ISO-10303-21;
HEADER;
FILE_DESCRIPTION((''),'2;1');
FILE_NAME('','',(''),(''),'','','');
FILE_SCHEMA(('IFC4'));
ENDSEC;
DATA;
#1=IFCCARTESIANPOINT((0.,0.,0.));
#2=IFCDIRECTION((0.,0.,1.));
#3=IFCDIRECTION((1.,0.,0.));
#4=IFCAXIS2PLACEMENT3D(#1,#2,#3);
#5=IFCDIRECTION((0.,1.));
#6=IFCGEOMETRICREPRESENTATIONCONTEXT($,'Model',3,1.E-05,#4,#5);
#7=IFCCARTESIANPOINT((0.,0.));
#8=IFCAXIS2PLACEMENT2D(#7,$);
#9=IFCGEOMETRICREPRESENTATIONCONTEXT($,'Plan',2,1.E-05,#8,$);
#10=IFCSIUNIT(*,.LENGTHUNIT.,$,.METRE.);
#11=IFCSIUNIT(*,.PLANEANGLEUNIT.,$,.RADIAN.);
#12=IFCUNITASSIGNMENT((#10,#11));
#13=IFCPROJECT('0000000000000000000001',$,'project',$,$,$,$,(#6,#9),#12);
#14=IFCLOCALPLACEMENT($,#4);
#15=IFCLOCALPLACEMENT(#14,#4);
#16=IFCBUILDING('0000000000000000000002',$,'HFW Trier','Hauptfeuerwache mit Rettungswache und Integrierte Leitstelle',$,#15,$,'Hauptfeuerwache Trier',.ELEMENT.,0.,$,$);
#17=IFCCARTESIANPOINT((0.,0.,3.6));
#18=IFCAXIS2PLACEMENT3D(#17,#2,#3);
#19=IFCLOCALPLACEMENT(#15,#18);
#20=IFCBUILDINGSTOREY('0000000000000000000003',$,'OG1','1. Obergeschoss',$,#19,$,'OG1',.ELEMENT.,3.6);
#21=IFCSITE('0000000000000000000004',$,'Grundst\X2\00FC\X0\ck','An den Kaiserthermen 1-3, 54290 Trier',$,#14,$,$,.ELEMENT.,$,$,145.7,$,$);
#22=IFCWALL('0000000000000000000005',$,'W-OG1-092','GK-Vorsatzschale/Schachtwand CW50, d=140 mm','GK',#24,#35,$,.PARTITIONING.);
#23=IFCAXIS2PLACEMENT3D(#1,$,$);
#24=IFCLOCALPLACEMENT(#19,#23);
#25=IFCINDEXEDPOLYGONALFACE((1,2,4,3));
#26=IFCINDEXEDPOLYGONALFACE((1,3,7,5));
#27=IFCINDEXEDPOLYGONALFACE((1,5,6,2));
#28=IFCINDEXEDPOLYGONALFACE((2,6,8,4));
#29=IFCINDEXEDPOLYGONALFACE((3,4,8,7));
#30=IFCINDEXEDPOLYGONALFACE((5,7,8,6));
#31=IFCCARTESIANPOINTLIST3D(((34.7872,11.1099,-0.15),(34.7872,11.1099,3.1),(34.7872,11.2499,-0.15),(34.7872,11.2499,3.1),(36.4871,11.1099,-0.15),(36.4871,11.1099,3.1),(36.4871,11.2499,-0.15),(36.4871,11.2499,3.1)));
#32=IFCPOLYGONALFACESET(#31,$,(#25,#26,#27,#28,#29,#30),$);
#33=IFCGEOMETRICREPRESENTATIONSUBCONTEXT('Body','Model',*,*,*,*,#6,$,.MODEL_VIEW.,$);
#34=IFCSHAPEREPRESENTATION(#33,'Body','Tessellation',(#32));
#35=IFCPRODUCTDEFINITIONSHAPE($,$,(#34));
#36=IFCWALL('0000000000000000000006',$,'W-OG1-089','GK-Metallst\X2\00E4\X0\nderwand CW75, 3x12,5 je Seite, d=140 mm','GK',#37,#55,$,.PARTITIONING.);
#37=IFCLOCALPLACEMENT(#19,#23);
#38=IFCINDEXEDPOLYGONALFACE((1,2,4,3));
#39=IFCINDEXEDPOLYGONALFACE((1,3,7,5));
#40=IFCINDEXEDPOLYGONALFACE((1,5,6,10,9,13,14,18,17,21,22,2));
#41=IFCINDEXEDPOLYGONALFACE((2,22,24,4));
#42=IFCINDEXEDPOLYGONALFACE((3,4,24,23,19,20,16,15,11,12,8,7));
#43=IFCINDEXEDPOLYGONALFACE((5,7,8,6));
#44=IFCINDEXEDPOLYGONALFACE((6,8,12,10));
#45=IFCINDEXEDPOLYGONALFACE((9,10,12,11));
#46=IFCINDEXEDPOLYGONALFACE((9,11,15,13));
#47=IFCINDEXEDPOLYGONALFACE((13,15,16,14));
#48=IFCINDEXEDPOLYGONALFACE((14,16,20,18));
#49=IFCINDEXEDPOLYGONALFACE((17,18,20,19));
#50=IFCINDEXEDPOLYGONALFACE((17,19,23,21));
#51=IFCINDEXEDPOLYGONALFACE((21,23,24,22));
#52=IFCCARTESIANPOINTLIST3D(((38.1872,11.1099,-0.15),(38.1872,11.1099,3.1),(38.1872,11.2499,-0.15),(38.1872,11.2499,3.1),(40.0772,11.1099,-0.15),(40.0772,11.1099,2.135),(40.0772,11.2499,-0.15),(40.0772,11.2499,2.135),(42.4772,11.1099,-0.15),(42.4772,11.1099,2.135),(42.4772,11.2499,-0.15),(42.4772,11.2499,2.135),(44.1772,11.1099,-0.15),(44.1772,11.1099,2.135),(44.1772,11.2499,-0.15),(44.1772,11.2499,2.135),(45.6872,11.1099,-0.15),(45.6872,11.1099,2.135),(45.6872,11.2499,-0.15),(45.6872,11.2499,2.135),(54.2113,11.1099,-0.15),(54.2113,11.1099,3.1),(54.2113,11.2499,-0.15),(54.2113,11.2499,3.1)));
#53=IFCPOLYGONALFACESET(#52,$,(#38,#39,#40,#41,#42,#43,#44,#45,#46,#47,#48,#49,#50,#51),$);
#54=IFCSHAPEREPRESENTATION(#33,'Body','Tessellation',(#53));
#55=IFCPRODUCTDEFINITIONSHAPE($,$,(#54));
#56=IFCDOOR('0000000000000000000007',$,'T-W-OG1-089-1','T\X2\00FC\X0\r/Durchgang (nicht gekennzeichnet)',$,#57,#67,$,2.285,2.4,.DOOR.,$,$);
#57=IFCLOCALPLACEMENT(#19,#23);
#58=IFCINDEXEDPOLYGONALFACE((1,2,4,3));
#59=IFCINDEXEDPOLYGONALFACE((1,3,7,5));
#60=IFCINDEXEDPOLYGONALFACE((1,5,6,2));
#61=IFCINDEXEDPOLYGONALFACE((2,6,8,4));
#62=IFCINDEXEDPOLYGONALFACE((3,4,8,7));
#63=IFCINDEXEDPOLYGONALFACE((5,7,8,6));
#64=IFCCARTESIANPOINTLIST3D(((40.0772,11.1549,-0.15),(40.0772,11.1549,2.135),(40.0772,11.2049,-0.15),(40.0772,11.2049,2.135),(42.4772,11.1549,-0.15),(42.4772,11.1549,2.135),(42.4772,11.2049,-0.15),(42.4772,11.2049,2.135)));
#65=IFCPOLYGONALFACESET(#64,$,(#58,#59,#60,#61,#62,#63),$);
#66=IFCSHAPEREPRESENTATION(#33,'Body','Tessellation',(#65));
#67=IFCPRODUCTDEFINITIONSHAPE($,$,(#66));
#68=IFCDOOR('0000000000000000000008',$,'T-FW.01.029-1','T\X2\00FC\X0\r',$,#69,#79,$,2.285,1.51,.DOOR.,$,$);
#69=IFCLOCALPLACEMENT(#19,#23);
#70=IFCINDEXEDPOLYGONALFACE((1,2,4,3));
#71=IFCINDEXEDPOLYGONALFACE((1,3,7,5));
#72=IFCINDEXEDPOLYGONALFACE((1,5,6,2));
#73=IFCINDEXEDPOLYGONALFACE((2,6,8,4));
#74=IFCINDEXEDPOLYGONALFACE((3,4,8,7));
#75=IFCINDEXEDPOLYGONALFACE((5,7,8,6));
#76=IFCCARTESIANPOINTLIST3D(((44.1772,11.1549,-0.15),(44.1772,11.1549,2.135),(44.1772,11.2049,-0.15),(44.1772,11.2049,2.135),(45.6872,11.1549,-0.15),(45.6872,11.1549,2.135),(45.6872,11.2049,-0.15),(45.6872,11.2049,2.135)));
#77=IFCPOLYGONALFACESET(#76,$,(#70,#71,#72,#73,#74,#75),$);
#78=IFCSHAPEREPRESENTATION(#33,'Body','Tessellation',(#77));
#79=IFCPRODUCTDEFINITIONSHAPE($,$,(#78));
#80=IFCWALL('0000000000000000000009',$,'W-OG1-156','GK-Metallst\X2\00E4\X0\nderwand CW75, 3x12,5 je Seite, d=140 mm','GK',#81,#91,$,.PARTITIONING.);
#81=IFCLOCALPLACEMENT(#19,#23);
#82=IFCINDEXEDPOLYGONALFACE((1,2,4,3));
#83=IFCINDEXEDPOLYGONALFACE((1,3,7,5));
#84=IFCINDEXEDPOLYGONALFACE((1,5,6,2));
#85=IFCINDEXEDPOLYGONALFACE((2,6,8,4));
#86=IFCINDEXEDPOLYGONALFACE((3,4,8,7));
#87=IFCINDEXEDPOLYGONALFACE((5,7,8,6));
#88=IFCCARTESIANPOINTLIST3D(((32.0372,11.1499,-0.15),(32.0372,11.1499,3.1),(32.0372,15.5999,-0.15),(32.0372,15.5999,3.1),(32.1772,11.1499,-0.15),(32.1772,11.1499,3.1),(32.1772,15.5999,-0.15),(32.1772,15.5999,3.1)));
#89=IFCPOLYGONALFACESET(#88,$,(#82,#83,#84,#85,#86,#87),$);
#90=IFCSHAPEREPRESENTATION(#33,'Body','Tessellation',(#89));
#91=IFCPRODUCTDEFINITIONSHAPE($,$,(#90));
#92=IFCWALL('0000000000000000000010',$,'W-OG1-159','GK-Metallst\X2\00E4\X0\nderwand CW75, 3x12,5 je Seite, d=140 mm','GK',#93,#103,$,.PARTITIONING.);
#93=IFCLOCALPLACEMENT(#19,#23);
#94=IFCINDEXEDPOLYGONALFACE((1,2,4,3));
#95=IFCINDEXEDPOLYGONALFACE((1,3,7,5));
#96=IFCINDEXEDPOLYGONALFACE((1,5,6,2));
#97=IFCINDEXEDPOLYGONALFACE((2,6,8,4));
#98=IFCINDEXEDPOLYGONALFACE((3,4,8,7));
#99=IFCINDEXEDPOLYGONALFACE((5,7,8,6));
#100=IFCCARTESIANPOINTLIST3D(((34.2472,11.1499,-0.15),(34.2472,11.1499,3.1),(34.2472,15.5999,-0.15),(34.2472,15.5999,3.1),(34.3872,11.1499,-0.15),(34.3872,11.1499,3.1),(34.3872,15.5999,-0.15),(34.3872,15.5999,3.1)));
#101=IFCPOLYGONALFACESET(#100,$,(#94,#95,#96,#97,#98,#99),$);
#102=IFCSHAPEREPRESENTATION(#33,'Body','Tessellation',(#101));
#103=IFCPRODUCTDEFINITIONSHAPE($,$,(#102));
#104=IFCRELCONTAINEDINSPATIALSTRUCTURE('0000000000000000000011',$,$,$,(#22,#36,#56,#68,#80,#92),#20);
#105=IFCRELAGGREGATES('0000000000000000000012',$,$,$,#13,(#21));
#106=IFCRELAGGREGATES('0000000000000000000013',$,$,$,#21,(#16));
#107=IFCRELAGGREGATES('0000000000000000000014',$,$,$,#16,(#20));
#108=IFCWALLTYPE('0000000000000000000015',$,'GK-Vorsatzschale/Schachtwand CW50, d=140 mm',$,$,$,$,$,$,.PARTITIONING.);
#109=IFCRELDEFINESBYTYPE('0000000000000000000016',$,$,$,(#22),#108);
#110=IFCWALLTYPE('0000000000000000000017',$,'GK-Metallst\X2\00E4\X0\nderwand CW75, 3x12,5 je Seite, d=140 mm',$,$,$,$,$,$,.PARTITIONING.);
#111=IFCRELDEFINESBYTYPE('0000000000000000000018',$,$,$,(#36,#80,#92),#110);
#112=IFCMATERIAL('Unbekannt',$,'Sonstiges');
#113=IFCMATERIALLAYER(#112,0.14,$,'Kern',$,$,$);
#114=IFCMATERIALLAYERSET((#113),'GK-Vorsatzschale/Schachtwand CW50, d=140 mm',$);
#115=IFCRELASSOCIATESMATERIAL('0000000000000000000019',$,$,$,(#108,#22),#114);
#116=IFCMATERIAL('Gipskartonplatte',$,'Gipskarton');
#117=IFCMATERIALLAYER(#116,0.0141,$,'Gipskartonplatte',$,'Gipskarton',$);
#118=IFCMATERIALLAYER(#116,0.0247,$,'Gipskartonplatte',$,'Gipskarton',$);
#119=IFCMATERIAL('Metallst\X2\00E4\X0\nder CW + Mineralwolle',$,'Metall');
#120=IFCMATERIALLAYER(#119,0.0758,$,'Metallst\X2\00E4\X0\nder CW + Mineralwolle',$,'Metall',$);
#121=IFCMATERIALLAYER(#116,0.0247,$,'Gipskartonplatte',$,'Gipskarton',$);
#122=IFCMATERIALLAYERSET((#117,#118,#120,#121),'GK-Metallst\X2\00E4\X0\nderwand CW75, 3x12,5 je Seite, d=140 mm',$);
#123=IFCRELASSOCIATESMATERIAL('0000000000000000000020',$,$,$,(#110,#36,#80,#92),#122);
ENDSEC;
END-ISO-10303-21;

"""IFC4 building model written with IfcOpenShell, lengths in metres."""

from ifc_helpers import new_model, si_unit, direction, frame, frame_2d, origin_with_axes, origin_2d, place, context, subcontext, project, spatial, rectangle, extrude, material, layer, layer_set, layer_usage, type_object, element, fill, save


model = new_model("IFC4")

# Units and contexts
model_context = context("Model", 3, precision=1e-05, world=origin_with_axes(), true_north=direction((0.0, 1.0)))
plan_context = context("Plan", 2, precision=1e-05, world=origin_2d())
body_context = subcontext(model_context, "Body", "Model", "MODEL_VIEW")
ifc_project = project(units=[si_unit("LENGTHUNIT", "METRE"), si_unit("PLANEANGLEUNIT", "RADIAN")], contexts=[model_context, plan_context])

# Site, building, storey
site_placement = place(None, origin_with_axes())
site = spatial("IfcSite", under=ifc_project, at=site_placement, Name="Grundstück", Description="An den Kaiserthermen 1-3, 54290 Trier", CompositionType="ELEMENT", RefElevation=145.7)
building_placement = place(site_placement, origin_with_axes())
building = spatial("IfcBuilding", under=site, at=building_placement, Name="HFW Trier", Description="Hauptfeuerwache mit Rettungswache und Integrierte Leitstelle", LongName="Hauptfeuerwache Trier", CompositionType="ELEMENT", ElevationOfRefHeight=0.0)
storey_placement = place(building_placement, frame((0.0, 0.0, 3.6), z_axis=(0.0, 0.0, 1.0), x_axis=(1.0, 0.0, 0.0)))
storey = spatial("IfcBuildingStorey", under=building, at=storey_placement, Name="OG1", Description="1. Obergeschoss", LongName="OG1", CompositionType="ELEMENT", Elevation=3.6)

# Wall
ifc_material_1 = material(Name="Gipskartonplatte", Category="Gipskarton")
ifc_material_2 = material(Name="Metallständer CW + Mineralwolle", Category="Metall")
ifc_material_3 = material(Name="Unbekannt", Category="Sonstiges")
ifc_layer_1 = layer(ifc_material_3, 0.14, Name="Kern")
ifc_layer_set_1 = layer_set([ifc_layer_1], Name="GK-Vorsatzschale/Schachtwand CW50, d=140 mm")
wall_type_1 = type_object("IfcWallType", Name="GK-Vorsatzschale/Schachtwand CW50, d=140 mm", PredefinedType="PARTITIONING", material=ifc_layer_set_1)
ifc_layer_usage_1 = layer_usage(ifc_layer_set_1, "AXIS2", "POSITIVE", -0.07)
wall_1_placement = place(storey_placement, frame((34.7872, 11.1799, -0.15), z_axis=(0.0, 0.0, 1.0), x_axis=(1.0, 0.0, 0.0)))
element("IfcWall", 1, at=wall_1_placement, inside=storey, type_object=wall_type_1, material=ifc_layer_usage_1, Name="W-OG1-092", Description="GK-Vorsatzschale/Schachtwand CW50, d=140 mm", ObjectType="GK", PredefinedType="PARTITIONING", context=body_context, shape_type="SweptSolid", body=[
    extrude(rectangle(XDim=1.6999, YDim=0.14, at=frame_2d((0.8499, 0.0))), origin_with_axes(), (0.0, 0.0, 1.0), 3.25),
])

# Wall, openings, doors
ifc_layer_2 = layer(ifc_material_1, 0.0141, Name="Gipskartonplatte", Category="Gipskarton")
ifc_layer_3 = layer(ifc_material_1, 0.0247, Name="Gipskartonplatte", Category="Gipskarton")
ifc_layer_4 = layer(ifc_material_2, 0.0758, Name="Metallständer CW + Mineralwolle", Category="Metall")
ifc_layer_5 = layer(ifc_material_1, 0.0247, Name="Gipskartonplatte", Category="Gipskarton")
ifc_layer_set_2 = layer_set([ifc_layer_2, ifc_layer_3, ifc_layer_4, ifc_layer_5], Name="GK-Metallständerwand CW75, 3x12,5 je Seite, d=140 mm")
ifc_layer_usage_2 = layer_usage(ifc_layer_set_2, "AXIS2", "POSITIVE", -0.07)
wall_type_2 = type_object("IfcWallType", Name="GK-Metallständerwand CW75, 3x12,5 je Seite, d=140 mm", PredefinedType="PARTITIONING", material=ifc_layer_set_2)
wall_2_placement = place(storey_placement, frame((38.1872, 11.1799, -0.15), z_axis=(0.0, 0.0, 1.0), x_axis=(1.0, 0.0, 0.0)))
wall_2 = element("IfcWall", 2, at=wall_2_placement, inside=storey, type_object=wall_type_2, material=ifc_layer_usage_2, Name="W-OG1-089", Description="GK-Metallständerwand CW75, 3x12,5 je Seite, d=140 mm", ObjectType="GK", PredefinedType="PARTITIONING", context=body_context, shape_type="SweptSolid", body=[
    extrude(rectangle(XDim=16.0241, YDim=0.14, at=frame_2d((8.0121, 0.0))), origin_with_axes(), (0.0, 0.0, 1.0), 3.25),
])
opening_1_placement = place(wall_2_placement, frame((1.89, 0.0, 0.0), z_axis=(0.0, 0.0, 1.0), x_axis=(1.0, 0.0, 0.0)))
opening_1 = element("IfcOpeningElement", 3, at=opening_1_placement, cuts=wall_2, PredefinedType="OPENING", context=body_context, shape_type="SweptSolid", body=[
    extrude(rectangle(XDim=2.4, YDim=0.24, at=frame_2d((1.2, 0.0))), origin_with_axes(), (0.0, 0.0, 1.0), 2.285),
])
opening_2_placement = place(wall_2_placement, frame((5.99, 0.0, 0.0), z_axis=(0.0, 0.0, 1.0), x_axis=(1.0, 0.0, 0.0)))
opening_2 = element("IfcOpeningElement", 4, at=opening_2_placement, cuts=wall_2, PredefinedType="OPENING", context=body_context, shape_type="SweptSolid", body=[
    extrude(rectangle(XDim=1.51, YDim=0.24, at=frame_2d((0.755, 0.0))), origin_with_axes(), (0.0, 0.0, 1.0), 2.285),
])
door_1_placement = place(wall_2_placement, frame((1.89, 0.0, 0.0), z_axis=(0.0, 0.0, 1.0), x_axis=(1.0, 0.0, 0.0)))
door_1 = element("IfcDoor", 5, at=door_1_placement, inside=storey, Name="T-W-OG1-089-1", Description="Tür/Durchgang (nicht gekennzeichnet)", OverallHeight=2.285, OverallWidth=2.4, PredefinedType="DOOR", context=body_context, shape_type="SweptSolid", body=[
    extrude(rectangle(XDim=2.4, YDim=0.05, at=frame_2d((1.2, 0.0))), origin_with_axes(), (0.0, 0.0, 1.0), 2.285),
])
fill(opening_1, door_1)
door_2_placement = place(wall_2_placement, frame((5.99, 0.0, 0.0), z_axis=(0.0, 0.0, 1.0), x_axis=(1.0, 0.0, 0.0)))
door_2 = element("IfcDoor", 6, at=door_2_placement, inside=storey, Name="T-FW.01.029-1", Description="Tür", OverallHeight=2.285, OverallWidth=1.51, PredefinedType="DOOR", context=body_context, shape_type="SweptSolid", body=[
    extrude(rectangle(XDim=1.51, YDim=0.05, at=frame_2d((0.755, 0.0))), origin_with_axes(), (0.0, 0.0, 1.0), 2.285),
])
fill(opening_2, door_2)

# Walls
ifc_layer_usage_3 = layer_usage(ifc_layer_set_2, "AXIS2", "POSITIVE", -0.07)
wall_3_placement = place(storey_placement, frame((32.1072, 15.5999, -0.15), z_axis=(0.0, 0.0, 1.0), x_axis=(0.0, -1.0, 0.0)))
element("IfcWall", 7, at=wall_3_placement, inside=storey, type_object=wall_type_2, material=ifc_layer_usage_3, Name="W-OG1-156", Description="GK-Metallständerwand CW75, 3x12,5 je Seite, d=140 mm", ObjectType="GK", PredefinedType="PARTITIONING", context=body_context, shape_type="SweptSolid", body=[
    extrude(rectangle(XDim=4.45, YDim=0.14, at=frame_2d((2.225, 0.0))), origin_with_axes(), (0.0, 0.0, 1.0), 3.25),
])
ifc_layer_usage_4 = layer_usage(ifc_layer_set_2, "AXIS2", "POSITIVE", -0.07)
wall_4_placement = place(storey_placement, frame((34.3172, 15.5999, -0.15), z_axis=(0.0, 0.0, 1.0), x_axis=(0.0, -1.0, 0.0)))
element("IfcWall", 8, at=wall_4_placement, inside=storey, type_object=wall_type_2, material=ifc_layer_usage_4, Name="W-OG1-159", Description="GK-Metallständerwand CW75, 3x12,5 je Seite, d=140 mm", ObjectType="GK", PredefinedType="PARTITIONING", context=body_context, shape_type="SweptSolid", body=[
    extrude(rectangle(XDim=4.45, YDim=0.14, at=frame_2d((2.225, 0.0))), origin_with_axes(), (0.0, 0.0, 1.0), 3.25),
])

save(model, "model.ifc")
